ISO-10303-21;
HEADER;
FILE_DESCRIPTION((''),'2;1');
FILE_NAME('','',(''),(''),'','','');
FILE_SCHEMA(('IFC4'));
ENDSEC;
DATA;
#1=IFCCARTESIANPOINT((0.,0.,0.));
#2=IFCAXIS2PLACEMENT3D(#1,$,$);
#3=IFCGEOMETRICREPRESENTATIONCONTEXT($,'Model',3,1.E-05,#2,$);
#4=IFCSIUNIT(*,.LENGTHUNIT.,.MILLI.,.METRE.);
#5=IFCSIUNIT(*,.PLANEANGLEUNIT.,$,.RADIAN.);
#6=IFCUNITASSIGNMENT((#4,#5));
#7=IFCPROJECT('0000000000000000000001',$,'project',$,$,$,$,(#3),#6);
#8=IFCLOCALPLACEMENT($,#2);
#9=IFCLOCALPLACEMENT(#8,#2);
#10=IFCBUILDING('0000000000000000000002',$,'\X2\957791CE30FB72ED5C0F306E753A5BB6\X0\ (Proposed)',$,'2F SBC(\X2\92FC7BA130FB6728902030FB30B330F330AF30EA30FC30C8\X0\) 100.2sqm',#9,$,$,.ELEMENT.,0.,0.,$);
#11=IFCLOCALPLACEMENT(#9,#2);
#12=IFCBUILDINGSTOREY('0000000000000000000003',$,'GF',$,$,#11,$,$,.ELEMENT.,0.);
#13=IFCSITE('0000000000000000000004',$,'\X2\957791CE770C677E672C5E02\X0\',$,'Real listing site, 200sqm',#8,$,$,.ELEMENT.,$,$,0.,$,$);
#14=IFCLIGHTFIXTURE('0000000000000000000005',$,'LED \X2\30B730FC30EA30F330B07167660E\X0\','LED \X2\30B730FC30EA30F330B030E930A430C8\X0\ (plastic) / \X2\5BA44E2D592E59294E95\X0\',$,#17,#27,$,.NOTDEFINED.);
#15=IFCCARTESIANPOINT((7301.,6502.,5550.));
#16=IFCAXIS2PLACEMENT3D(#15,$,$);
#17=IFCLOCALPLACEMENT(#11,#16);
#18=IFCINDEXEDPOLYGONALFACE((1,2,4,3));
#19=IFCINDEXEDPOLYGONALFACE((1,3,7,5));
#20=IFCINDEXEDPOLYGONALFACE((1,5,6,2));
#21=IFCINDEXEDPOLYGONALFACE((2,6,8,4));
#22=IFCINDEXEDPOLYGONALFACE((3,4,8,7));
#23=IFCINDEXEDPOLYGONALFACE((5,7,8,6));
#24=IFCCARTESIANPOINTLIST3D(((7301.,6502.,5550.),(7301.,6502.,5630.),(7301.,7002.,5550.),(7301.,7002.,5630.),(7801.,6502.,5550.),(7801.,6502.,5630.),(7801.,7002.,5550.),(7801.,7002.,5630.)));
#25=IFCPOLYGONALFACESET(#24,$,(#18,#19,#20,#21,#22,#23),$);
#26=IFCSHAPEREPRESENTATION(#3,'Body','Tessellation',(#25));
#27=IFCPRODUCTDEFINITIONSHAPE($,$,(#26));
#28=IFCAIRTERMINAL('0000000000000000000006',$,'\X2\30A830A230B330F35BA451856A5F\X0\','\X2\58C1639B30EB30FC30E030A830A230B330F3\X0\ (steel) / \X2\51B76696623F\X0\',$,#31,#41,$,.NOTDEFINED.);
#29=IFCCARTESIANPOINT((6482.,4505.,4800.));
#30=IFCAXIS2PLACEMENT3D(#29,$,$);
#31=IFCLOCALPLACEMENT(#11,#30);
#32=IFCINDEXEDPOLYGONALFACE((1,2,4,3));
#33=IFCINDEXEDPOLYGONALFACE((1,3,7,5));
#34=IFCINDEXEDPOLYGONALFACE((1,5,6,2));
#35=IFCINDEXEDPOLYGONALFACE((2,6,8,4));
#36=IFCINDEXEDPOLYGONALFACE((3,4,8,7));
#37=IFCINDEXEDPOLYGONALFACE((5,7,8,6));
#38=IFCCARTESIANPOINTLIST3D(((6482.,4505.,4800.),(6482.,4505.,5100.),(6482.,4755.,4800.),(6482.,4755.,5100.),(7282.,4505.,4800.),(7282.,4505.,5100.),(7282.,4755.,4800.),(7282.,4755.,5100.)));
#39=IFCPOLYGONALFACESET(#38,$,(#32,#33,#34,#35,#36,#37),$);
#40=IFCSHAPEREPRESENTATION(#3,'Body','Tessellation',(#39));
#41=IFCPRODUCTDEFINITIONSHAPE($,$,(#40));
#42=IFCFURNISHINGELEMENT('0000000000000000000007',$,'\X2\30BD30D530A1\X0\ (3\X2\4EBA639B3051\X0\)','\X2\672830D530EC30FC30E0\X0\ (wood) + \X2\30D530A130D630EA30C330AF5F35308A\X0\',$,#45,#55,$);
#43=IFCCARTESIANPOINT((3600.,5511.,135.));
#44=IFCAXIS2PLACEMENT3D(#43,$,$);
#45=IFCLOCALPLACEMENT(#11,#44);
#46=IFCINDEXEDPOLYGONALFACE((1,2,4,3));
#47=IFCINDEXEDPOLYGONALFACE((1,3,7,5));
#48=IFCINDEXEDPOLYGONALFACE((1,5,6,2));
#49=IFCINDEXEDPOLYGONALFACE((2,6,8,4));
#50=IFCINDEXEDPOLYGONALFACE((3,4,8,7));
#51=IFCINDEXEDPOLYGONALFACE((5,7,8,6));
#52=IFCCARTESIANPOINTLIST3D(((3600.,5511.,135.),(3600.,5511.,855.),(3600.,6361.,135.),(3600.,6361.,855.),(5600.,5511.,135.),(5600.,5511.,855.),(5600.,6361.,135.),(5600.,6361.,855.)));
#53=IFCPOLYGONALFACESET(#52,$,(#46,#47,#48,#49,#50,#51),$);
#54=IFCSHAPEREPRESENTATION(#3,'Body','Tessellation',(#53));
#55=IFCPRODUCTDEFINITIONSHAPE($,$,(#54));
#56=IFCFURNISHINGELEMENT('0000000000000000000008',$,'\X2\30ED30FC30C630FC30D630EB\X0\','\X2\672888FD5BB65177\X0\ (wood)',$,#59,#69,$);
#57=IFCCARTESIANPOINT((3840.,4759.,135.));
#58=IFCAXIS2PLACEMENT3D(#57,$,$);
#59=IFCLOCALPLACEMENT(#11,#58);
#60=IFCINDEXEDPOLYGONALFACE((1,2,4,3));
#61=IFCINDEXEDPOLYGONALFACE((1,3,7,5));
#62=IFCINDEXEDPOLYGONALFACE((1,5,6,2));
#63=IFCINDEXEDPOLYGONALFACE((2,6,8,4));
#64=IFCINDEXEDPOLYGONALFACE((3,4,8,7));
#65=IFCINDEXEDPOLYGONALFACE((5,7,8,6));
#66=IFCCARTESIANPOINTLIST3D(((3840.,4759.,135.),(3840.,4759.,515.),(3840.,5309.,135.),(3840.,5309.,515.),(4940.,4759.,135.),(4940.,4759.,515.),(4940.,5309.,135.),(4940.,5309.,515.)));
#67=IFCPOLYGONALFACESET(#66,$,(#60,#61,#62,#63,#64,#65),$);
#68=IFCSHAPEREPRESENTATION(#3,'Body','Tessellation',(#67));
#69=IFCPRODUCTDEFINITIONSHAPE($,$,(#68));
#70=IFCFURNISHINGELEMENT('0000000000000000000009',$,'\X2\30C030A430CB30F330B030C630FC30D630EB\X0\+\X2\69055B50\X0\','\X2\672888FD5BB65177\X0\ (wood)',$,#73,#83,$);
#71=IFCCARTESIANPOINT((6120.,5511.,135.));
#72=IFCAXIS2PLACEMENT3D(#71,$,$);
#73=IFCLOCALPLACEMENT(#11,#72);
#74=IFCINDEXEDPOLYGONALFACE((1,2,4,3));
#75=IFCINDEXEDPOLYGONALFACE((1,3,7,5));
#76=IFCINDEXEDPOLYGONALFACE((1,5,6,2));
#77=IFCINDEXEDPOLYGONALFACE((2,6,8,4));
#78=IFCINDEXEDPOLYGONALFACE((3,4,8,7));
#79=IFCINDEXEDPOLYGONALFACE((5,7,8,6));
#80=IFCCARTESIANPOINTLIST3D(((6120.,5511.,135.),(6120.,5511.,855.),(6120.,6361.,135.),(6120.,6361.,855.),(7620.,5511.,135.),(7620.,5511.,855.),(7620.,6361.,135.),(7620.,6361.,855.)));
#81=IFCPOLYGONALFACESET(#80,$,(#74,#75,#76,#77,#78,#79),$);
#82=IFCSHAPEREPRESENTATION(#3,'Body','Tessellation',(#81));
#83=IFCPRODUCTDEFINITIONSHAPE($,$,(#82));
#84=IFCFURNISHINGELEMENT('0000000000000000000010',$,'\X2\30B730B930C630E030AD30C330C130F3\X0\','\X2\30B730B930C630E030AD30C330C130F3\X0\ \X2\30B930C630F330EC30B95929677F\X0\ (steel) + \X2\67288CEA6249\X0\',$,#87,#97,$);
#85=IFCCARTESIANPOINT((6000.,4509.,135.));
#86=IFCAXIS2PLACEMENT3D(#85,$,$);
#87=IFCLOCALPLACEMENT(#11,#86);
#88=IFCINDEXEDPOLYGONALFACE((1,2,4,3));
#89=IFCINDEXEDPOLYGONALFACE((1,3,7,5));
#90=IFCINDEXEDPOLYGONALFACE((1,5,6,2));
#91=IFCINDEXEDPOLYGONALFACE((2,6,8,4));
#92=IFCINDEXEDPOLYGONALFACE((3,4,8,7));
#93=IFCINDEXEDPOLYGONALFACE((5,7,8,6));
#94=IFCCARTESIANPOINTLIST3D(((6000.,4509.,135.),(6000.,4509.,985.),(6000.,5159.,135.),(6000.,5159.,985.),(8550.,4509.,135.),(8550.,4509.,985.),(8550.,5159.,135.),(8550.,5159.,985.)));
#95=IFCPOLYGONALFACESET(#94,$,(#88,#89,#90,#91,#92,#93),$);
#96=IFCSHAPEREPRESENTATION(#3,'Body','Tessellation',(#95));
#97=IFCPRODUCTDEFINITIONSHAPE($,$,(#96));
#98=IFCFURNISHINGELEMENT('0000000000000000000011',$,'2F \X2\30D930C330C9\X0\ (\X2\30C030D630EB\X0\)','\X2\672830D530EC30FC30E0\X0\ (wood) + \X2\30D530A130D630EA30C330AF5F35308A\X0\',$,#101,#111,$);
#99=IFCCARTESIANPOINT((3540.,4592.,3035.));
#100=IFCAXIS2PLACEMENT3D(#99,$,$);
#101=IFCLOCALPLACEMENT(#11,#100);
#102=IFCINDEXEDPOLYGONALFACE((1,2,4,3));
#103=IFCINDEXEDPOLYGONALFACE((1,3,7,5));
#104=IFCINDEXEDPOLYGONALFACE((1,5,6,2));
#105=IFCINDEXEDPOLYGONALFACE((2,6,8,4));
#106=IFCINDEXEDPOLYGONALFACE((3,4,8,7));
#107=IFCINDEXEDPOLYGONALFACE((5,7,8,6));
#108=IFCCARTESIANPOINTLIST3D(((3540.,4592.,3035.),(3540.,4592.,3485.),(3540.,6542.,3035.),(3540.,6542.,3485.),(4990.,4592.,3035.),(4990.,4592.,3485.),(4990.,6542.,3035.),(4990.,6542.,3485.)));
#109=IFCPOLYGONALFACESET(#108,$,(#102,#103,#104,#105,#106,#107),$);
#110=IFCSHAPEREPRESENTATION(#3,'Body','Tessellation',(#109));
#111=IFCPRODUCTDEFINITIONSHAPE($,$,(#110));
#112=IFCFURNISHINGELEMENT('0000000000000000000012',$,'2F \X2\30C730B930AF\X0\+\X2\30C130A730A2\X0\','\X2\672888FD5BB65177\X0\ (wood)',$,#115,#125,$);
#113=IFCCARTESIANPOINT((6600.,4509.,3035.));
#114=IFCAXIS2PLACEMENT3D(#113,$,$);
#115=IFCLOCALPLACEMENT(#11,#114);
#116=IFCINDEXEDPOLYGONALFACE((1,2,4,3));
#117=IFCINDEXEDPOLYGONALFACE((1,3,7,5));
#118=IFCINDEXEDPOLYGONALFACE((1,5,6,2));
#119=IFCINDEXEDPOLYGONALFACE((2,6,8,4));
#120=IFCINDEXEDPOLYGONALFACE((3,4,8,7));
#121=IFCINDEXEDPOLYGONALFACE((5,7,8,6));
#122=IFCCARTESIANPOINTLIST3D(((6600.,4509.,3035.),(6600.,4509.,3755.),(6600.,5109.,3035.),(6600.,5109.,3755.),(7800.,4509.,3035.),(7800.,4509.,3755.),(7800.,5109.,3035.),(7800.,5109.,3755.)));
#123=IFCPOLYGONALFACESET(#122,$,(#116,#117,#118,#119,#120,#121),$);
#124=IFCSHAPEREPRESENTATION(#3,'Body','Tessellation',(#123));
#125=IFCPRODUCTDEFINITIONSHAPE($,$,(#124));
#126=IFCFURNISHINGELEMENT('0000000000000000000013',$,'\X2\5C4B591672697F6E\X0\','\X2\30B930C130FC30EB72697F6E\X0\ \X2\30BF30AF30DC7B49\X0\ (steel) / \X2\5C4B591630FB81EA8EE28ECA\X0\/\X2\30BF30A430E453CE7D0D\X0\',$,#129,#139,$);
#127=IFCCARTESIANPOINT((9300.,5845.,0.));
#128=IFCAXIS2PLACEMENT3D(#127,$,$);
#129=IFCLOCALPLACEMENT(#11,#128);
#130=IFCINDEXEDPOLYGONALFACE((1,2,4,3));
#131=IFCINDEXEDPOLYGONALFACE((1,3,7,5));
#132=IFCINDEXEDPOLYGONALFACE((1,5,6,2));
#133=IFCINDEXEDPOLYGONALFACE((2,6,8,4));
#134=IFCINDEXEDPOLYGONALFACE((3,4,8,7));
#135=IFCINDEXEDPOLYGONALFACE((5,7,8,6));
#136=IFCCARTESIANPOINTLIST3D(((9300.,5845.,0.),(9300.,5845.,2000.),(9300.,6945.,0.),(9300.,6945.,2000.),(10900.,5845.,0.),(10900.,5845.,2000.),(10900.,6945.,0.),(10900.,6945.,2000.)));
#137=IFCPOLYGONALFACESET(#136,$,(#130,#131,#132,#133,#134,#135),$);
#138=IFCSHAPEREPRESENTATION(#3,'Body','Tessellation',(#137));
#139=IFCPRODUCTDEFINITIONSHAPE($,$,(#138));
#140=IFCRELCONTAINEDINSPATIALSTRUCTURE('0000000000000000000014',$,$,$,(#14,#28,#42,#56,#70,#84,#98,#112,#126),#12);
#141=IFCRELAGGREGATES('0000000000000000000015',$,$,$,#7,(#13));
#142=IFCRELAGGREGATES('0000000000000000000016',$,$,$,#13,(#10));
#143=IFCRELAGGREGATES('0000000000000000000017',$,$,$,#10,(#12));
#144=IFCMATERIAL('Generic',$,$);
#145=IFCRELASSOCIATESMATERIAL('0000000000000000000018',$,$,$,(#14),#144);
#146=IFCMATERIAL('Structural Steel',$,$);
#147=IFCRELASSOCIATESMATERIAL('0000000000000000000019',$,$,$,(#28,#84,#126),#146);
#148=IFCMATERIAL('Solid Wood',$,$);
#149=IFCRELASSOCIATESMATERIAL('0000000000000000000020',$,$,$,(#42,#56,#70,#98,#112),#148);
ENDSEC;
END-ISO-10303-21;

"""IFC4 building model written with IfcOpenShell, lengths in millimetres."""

from ifc_helpers import new_model, si_unit, frame, frame_2d, origin, place, context, project, spatial, rectangle, extrude, material, element, save


model = new_model("IFC4")

# Units and contexts
model_context = context("Model", 3, precision=1e-05, world=origin())
ifc_project = project(units=[si_unit("LENGTHUNIT", "METRE", prefix="MILLI"), si_unit("PLANEANGLEUNIT", "RADIAN")], contexts=[model_context])

# Site, building, storey
site_placement = place(None, origin())
site = spatial("IfcSite", under=ifc_project, at=site_placement, Name="長野県松本市", ObjectType="Real listing site, 200sqm", CompositionType="ELEMENT", RefElevation=0.0)
building_placement = place(site_placement, origin())
building = spatial("IfcBuilding", under=site, at=building_placement, Name="長野・狭小の町家 (Proposed)", ObjectType="2F SBC(鋼管・木造・コンクリート) 100.2sqm", CompositionType="ELEMENT", ElevationOfRefHeight=0.0, ElevationOfTerrain=0.0)
storey_placement = place(building_placement, origin())
storey = spatial("IfcBuildingStorey", under=building, at=storey_placement, Name="GF", CompositionType="ELEMENT", Elevation=0.0)

# Shared definitions
ifc_material_1 = material(Name="Solid Wood")

# Shared definitions
ifc_material_2 = material(Name="Generic")

# Shared definitions
ifc_material_3 = material(Name="Structural Steel")

# Light fixture
light_fixture_placement = place(storey_placement, frame((7301.0, 6502.0, 5550.0)))
element("IfcLightFixture", 1, at=light_fixture_placement, inside=storey, material=ifc_material_2, Name="LED シーリング照明", Description="LED シーリングライト (plastic) / 室中央天井", PredefinedType="NOTDEFINED", context=model_context, shape_type="SweptSolid", body=[
    extrude(rectangle(XDim=500.0, YDim=500.0, at=frame_2d((250.0, 250.0))), frame((7301.0, 6502.0, 5550.0)), (0.0, 0.0, 1.0), 80.0),
])

# Air terminal
air_terminal_1_placement = place(storey_placement, frame((6482.0, 4505.0, 4800.0)))
element("IfcAirTerminal", 2, at=air_terminal_1_placement, inside=storey, material=ifc_material_3, Name="エアコン室内機", Description="壁掛ルームエアコン (steel) / 冷暖房", PredefinedType="NOTDEFINED", context=model_context, shape_type="SweptSolid", body=[
    extrude(rectangle(XDim=800.0, YDim=250.0, at=frame_2d((400.0, 125.0))), frame((6482.0, 4505.0, 4800.0)), (0.0, 0.0, 1.0), 300.0),
])

# Furnishing elements
furnishing_1_placement = place(storey_placement, frame((3600.0, 5511.0, 135.0)))
element("IfcFurnishingElement", 3, at=furnishing_1_placement, inside=storey, material=ifc_material_1, Name="ソファ (3人掛け)", Description="木フレーム (wood) + ファブリック張り", context=model_context, shape_type="SweptSolid", body=[
    extrude(rectangle(XDim=2000.0, YDim=850.0, at=frame_2d((1000.0, 425.0))), frame((3600.0, 5511.0, 135.0)), (0.0, 0.0, 1.0), 720.0),
])
furnishing_2_placement = place(storey_placement, frame((3840.0, 4759.0, 135.0)))
element("IfcFurnishingElement", 4, at=furnishing_2_placement, inside=storey, material=ifc_material_1, Name="ローテーブル", Description="木製家具 (wood)", context=model_context, shape_type="SweptSolid", body=[
    extrude(rectangle(XDim=1100.0, YDim=550.0, at=frame_2d((550.0, 275.0))), frame((3840.0, 4759.0, 135.0)), (0.0, 0.0, 1.0), 380.0),
])
furnishing_3_placement = place(storey_placement, frame((6120.0, 5511.0, 135.0)))
element("IfcFurnishingElement", 5, at=furnishing_3_placement, inside=storey, material=ifc_material_1, Name="ダイニングテーブル+椅子", Description="木製家具 (wood)", context=model_context, shape_type="SweptSolid", body=[
    extrude(rectangle(XDim=1500.0, YDim=850.0, at=frame_2d((750.0, 425.0))), frame((6120.0, 5511.0, 135.0)), (0.0, 0.0, 1.0), 720.0),
])
furnishing_4_placement = place(storey_placement, frame((6000.0, 4509.0, 135.0)))
element("IfcFurnishingElement", 6, at=furnishing_4_placement, inside=storey, material=ifc_material_3, Name="システムキッチン", Description="システムキッチン ステンレス天板 (steel) + 木質扉", context=model_context, shape_type="SweptSolid", body=[
    extrude(rectangle(XDim=2550.0, YDim=650.0, at=frame_2d((1275.0, 325.0))), frame((6000.0, 4509.0, 135.0)), (0.0, 0.0, 1.0), 850.0),
])
furnishing_5_placement = place(storey_placement, frame((3540.0, 4592.0, 3035.0)))
element("IfcFurnishingElement", 7, at=furnishing_5_placement, inside=storey, material=ifc_material_1, Name="2F ベッド (ダブル)", Description="木フレーム (wood) + ファブリック張り", context=model_context, shape_type="SweptSolid", body=[
    extrude(rectangle(XDim=1450.0, YDim=1950.0, at=frame_2d((725.0, 975.0))), frame((3540.0, 4592.0, 3035.0)), (0.0, 0.0, 1.0), 450.0),
])
furnishing_6_placement = place(storey_placement, frame((6600.0, 4509.0, 3035.0)))
element("IfcFurnishingElement", 8, at=furnishing_6_placement, inside=storey, material=ifc_material_1, Name="2F デスク+チェア", Description="木製家具 (wood)", context=model_context, shape_type="SweptSolid", body=[
    extrude(rectangle(XDim=1200.0, YDim=600.0, at=frame_2d((600.0, 300.0))), frame((6600.0, 4509.0, 3035.0)), (0.0, 0.0, 1.0), 720.0),
])
furnishing_7_placement = place(storey_placement, frame((9300.0, 5845.0, 0.0)))
element("IfcFurnishingElement", 9, at=furnishing_7_placement, inside=storey, material=ifc_material_3, Name="屋外物置", Description="スチール物置 タクボ等 (steel) / 屋外・自転車/タイヤ収納", context=model_context, shape_type="SweptSolid", body=[
    extrude(rectangle(XDim=1600.0, YDim=1100.0, at=frame_2d((800.0, 550.0))), frame((9300.0, 5845.0, 0.0)), (0.0, 0.0, 1.0), 2000.0),
])

save(model, "model.ifc")
